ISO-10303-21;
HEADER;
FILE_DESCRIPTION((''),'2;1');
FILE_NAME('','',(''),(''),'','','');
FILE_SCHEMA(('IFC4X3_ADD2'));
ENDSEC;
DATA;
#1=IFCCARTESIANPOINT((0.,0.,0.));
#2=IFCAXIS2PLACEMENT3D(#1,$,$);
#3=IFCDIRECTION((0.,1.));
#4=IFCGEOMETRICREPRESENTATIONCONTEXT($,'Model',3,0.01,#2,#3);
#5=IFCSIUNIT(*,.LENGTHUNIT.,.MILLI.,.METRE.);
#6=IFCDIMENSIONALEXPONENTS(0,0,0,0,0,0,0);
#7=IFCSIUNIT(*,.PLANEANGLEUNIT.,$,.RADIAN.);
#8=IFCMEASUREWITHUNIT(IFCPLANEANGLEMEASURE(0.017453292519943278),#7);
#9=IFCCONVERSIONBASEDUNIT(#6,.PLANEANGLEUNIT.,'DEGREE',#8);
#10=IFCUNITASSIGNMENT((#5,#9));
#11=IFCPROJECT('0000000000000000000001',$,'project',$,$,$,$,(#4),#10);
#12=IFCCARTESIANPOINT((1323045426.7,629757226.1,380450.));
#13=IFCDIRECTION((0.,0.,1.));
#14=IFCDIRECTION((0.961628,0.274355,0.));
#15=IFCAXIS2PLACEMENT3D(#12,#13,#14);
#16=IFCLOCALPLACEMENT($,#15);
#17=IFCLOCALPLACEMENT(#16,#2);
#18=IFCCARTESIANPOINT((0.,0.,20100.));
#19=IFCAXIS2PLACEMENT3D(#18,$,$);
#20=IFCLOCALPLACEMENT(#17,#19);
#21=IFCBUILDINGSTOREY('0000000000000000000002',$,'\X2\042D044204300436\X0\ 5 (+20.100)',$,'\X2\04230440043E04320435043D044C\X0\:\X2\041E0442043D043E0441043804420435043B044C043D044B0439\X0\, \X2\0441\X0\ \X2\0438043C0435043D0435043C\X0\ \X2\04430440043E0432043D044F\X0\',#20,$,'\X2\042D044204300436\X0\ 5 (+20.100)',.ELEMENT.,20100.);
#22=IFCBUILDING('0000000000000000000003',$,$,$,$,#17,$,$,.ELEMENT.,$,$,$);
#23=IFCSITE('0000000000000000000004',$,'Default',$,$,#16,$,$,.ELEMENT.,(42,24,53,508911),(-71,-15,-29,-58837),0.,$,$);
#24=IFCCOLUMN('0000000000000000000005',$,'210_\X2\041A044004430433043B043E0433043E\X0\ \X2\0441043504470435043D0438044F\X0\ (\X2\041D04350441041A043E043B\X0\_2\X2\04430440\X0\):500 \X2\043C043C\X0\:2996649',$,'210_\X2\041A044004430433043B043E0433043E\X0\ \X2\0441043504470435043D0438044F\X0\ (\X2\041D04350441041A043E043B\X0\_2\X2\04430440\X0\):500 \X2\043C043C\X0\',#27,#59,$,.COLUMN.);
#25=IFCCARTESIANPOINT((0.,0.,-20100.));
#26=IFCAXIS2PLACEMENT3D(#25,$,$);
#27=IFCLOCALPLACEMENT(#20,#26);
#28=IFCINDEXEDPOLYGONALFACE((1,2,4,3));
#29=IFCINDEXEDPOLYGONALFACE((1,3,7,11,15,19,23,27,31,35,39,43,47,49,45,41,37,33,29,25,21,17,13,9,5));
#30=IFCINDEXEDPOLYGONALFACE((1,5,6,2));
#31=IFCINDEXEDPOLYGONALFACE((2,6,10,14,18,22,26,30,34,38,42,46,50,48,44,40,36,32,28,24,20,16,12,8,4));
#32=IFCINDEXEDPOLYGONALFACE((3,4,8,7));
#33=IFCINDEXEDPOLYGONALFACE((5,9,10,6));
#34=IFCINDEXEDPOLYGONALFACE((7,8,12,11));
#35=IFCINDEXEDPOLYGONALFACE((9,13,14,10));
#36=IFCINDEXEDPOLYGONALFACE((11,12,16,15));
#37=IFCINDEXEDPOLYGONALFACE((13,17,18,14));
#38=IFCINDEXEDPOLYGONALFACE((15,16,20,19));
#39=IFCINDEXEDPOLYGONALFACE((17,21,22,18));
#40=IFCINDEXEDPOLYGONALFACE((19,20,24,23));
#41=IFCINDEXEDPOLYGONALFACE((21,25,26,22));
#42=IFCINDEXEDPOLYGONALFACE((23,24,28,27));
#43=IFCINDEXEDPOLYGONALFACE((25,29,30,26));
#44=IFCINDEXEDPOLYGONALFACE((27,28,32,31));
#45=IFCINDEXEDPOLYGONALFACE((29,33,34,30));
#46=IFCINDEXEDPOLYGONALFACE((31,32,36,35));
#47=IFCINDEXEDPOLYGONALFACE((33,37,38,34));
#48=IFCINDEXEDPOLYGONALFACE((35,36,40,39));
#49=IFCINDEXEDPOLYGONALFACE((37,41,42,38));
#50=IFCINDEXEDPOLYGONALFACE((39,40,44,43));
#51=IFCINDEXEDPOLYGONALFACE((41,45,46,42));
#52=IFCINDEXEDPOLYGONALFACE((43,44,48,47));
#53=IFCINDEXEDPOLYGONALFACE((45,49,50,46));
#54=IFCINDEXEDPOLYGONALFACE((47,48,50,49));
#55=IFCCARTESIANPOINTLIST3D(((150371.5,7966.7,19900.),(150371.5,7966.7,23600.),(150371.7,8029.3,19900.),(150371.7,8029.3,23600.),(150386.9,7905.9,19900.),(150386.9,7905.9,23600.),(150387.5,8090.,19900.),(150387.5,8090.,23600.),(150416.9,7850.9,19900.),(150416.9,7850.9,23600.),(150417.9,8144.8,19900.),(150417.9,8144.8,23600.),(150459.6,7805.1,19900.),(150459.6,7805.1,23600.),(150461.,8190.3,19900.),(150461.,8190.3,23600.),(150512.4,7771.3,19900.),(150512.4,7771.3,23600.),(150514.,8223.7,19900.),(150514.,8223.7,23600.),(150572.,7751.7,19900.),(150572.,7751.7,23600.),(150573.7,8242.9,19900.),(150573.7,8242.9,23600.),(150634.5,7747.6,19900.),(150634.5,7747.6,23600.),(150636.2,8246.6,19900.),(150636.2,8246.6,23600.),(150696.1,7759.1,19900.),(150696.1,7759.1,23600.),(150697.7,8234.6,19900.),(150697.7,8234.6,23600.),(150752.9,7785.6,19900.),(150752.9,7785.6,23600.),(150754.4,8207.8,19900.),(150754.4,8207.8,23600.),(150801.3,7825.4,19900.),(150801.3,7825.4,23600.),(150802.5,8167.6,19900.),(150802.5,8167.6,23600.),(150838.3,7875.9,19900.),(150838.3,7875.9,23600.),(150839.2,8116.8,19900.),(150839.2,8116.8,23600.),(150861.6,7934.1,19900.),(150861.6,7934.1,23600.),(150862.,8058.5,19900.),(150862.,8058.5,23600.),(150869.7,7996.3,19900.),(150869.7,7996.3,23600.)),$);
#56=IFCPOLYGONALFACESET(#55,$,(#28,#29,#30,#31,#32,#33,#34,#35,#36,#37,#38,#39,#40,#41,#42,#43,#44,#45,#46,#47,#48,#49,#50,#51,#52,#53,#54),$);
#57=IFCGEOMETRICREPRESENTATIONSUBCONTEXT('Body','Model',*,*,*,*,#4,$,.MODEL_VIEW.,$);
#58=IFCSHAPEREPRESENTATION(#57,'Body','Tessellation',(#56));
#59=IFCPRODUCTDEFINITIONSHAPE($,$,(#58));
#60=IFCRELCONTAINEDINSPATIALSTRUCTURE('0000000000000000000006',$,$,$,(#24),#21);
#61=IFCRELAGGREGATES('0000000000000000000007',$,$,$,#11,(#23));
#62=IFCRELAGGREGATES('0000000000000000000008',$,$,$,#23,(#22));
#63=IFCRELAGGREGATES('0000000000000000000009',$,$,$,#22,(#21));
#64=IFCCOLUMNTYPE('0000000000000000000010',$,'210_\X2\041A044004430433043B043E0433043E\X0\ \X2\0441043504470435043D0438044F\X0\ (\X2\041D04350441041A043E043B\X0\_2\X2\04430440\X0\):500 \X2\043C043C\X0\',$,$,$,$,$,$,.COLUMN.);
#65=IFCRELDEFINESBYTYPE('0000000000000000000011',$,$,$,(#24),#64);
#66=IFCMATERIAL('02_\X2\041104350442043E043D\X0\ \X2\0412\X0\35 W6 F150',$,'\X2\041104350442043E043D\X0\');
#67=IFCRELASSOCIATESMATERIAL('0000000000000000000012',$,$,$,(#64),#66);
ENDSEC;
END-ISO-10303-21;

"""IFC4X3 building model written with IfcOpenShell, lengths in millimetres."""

from ifc_helpers import new_model, entity, si_unit, converted_unit, direction, frame, frame_2d, origin, place, context, subcontext, project, spatial, circle, extrude, source, transform, mapped, material, material_profile, profile_set, type_object, type_shapes, element, save


model = new_model("IFC4X3")

# Units and contexts
model_context = context("Model", 3, precision=0.01, world=origin(), true_north=direction((0.0, 1.0)))
body_context = subcontext(model_context, "Body", "Model", "MODEL_VIEW")
ifc_project = project(units=[si_unit("LENGTHUNIT", "METRE", prefix="MILLI"), converted_unit("PLANEANGLEUNIT", "DEGREE", entity("IfcPlaneAngleMeasure", 0.017453292519943278), si_unit("PLANEANGLEUNIT", "RADIAN"), dimensions=[0, 0, 0, 0, 0, 0, 0])], contexts=[model_context])

# Site, building, storey
site_placement = place(None, frame((1323045426.7, 629757226.1, 380450.0), z_axis=(0.0, 0.0, 1.0), x_axis=(0.961628, 0.274355, 0.0)))
site = spatial("IfcSite", under=ifc_project, at=site_placement, Name="Default", CompositionType="ELEMENT", RefLatitude=(42, 24, 53, 508911), RefLongitude=(-71, -15, -29, -58837), RefElevation=0.0)
building_placement = place(site_placement, origin())
building = spatial("IfcBuilding", under=site, at=building_placement, CompositionType="ELEMENT")
storey_placement = place(building_placement, frame((0.0, 0.0, 20100.0)))
storey = spatial("IfcBuildingStorey", under=building, at=storey_placement, Name="Этаж 5 (+20.100)", ObjectType="Уровень:Относительный, с именем уровня", LongName="Этаж 5 (+20.100)", CompositionType="ELEMENT", Elevation=20100.0)

# Column
ifc_material_1 = material(Name="02_Бетон В35 W6 F150", Category="Бетон")
ifc_material_profile_1 = material_profile(ifc_material_1, circle(Radius=250.0, at=frame_2d((0.0, 0.0), x_axis=(1.0, 0.0))), Name="500 мм")
ifc_profile_set_1 = profile_set([ifc_material_profile_1], Name="500 мм")
column_type_1 = type_object("IfcColumnType", Name="210_Круглого сечения (НесКол_2ур):500 мм", PredefinedType="COLUMN", material=ifc_profile_set_1)
shared_shape_1 = source(origin(), body_context, "Body", "SweptSolid", [
    extrude(circle(Radius=250.0, at=frame_2d((0.0, 0.0), x_axis=(1.0, 0.0))), frame((150619.7, 7997.1, 19900.0), z_axis=(0.0, 0.0, 1.0), x_axis=(0.87462, -0.48481, 0.0)), (0.0, 0.0, 1.0), 3700.0),
])
type_shapes(column_type_1, [shared_shape_1])
column_1_placement = place(storey_placement, frame((0.0, 0.0, -20100.0)))
element("IfcColumn", 1, at=column_1_placement, inside=storey, type_object=column_type_1, Name="210_Круглого сечения (НесКол_2ур):500 мм:2996649", ObjectType="210_Круглого сечения (НесКол_2ур):500 мм", PredefinedType="COLUMN", context=body_context, shape_type="MappedRepresentation", body=[
    mapped(shared_shape_1, transform((0.0, 0.0, 0.0), scale=1.0)),
])

save(model, "model.ifc")
